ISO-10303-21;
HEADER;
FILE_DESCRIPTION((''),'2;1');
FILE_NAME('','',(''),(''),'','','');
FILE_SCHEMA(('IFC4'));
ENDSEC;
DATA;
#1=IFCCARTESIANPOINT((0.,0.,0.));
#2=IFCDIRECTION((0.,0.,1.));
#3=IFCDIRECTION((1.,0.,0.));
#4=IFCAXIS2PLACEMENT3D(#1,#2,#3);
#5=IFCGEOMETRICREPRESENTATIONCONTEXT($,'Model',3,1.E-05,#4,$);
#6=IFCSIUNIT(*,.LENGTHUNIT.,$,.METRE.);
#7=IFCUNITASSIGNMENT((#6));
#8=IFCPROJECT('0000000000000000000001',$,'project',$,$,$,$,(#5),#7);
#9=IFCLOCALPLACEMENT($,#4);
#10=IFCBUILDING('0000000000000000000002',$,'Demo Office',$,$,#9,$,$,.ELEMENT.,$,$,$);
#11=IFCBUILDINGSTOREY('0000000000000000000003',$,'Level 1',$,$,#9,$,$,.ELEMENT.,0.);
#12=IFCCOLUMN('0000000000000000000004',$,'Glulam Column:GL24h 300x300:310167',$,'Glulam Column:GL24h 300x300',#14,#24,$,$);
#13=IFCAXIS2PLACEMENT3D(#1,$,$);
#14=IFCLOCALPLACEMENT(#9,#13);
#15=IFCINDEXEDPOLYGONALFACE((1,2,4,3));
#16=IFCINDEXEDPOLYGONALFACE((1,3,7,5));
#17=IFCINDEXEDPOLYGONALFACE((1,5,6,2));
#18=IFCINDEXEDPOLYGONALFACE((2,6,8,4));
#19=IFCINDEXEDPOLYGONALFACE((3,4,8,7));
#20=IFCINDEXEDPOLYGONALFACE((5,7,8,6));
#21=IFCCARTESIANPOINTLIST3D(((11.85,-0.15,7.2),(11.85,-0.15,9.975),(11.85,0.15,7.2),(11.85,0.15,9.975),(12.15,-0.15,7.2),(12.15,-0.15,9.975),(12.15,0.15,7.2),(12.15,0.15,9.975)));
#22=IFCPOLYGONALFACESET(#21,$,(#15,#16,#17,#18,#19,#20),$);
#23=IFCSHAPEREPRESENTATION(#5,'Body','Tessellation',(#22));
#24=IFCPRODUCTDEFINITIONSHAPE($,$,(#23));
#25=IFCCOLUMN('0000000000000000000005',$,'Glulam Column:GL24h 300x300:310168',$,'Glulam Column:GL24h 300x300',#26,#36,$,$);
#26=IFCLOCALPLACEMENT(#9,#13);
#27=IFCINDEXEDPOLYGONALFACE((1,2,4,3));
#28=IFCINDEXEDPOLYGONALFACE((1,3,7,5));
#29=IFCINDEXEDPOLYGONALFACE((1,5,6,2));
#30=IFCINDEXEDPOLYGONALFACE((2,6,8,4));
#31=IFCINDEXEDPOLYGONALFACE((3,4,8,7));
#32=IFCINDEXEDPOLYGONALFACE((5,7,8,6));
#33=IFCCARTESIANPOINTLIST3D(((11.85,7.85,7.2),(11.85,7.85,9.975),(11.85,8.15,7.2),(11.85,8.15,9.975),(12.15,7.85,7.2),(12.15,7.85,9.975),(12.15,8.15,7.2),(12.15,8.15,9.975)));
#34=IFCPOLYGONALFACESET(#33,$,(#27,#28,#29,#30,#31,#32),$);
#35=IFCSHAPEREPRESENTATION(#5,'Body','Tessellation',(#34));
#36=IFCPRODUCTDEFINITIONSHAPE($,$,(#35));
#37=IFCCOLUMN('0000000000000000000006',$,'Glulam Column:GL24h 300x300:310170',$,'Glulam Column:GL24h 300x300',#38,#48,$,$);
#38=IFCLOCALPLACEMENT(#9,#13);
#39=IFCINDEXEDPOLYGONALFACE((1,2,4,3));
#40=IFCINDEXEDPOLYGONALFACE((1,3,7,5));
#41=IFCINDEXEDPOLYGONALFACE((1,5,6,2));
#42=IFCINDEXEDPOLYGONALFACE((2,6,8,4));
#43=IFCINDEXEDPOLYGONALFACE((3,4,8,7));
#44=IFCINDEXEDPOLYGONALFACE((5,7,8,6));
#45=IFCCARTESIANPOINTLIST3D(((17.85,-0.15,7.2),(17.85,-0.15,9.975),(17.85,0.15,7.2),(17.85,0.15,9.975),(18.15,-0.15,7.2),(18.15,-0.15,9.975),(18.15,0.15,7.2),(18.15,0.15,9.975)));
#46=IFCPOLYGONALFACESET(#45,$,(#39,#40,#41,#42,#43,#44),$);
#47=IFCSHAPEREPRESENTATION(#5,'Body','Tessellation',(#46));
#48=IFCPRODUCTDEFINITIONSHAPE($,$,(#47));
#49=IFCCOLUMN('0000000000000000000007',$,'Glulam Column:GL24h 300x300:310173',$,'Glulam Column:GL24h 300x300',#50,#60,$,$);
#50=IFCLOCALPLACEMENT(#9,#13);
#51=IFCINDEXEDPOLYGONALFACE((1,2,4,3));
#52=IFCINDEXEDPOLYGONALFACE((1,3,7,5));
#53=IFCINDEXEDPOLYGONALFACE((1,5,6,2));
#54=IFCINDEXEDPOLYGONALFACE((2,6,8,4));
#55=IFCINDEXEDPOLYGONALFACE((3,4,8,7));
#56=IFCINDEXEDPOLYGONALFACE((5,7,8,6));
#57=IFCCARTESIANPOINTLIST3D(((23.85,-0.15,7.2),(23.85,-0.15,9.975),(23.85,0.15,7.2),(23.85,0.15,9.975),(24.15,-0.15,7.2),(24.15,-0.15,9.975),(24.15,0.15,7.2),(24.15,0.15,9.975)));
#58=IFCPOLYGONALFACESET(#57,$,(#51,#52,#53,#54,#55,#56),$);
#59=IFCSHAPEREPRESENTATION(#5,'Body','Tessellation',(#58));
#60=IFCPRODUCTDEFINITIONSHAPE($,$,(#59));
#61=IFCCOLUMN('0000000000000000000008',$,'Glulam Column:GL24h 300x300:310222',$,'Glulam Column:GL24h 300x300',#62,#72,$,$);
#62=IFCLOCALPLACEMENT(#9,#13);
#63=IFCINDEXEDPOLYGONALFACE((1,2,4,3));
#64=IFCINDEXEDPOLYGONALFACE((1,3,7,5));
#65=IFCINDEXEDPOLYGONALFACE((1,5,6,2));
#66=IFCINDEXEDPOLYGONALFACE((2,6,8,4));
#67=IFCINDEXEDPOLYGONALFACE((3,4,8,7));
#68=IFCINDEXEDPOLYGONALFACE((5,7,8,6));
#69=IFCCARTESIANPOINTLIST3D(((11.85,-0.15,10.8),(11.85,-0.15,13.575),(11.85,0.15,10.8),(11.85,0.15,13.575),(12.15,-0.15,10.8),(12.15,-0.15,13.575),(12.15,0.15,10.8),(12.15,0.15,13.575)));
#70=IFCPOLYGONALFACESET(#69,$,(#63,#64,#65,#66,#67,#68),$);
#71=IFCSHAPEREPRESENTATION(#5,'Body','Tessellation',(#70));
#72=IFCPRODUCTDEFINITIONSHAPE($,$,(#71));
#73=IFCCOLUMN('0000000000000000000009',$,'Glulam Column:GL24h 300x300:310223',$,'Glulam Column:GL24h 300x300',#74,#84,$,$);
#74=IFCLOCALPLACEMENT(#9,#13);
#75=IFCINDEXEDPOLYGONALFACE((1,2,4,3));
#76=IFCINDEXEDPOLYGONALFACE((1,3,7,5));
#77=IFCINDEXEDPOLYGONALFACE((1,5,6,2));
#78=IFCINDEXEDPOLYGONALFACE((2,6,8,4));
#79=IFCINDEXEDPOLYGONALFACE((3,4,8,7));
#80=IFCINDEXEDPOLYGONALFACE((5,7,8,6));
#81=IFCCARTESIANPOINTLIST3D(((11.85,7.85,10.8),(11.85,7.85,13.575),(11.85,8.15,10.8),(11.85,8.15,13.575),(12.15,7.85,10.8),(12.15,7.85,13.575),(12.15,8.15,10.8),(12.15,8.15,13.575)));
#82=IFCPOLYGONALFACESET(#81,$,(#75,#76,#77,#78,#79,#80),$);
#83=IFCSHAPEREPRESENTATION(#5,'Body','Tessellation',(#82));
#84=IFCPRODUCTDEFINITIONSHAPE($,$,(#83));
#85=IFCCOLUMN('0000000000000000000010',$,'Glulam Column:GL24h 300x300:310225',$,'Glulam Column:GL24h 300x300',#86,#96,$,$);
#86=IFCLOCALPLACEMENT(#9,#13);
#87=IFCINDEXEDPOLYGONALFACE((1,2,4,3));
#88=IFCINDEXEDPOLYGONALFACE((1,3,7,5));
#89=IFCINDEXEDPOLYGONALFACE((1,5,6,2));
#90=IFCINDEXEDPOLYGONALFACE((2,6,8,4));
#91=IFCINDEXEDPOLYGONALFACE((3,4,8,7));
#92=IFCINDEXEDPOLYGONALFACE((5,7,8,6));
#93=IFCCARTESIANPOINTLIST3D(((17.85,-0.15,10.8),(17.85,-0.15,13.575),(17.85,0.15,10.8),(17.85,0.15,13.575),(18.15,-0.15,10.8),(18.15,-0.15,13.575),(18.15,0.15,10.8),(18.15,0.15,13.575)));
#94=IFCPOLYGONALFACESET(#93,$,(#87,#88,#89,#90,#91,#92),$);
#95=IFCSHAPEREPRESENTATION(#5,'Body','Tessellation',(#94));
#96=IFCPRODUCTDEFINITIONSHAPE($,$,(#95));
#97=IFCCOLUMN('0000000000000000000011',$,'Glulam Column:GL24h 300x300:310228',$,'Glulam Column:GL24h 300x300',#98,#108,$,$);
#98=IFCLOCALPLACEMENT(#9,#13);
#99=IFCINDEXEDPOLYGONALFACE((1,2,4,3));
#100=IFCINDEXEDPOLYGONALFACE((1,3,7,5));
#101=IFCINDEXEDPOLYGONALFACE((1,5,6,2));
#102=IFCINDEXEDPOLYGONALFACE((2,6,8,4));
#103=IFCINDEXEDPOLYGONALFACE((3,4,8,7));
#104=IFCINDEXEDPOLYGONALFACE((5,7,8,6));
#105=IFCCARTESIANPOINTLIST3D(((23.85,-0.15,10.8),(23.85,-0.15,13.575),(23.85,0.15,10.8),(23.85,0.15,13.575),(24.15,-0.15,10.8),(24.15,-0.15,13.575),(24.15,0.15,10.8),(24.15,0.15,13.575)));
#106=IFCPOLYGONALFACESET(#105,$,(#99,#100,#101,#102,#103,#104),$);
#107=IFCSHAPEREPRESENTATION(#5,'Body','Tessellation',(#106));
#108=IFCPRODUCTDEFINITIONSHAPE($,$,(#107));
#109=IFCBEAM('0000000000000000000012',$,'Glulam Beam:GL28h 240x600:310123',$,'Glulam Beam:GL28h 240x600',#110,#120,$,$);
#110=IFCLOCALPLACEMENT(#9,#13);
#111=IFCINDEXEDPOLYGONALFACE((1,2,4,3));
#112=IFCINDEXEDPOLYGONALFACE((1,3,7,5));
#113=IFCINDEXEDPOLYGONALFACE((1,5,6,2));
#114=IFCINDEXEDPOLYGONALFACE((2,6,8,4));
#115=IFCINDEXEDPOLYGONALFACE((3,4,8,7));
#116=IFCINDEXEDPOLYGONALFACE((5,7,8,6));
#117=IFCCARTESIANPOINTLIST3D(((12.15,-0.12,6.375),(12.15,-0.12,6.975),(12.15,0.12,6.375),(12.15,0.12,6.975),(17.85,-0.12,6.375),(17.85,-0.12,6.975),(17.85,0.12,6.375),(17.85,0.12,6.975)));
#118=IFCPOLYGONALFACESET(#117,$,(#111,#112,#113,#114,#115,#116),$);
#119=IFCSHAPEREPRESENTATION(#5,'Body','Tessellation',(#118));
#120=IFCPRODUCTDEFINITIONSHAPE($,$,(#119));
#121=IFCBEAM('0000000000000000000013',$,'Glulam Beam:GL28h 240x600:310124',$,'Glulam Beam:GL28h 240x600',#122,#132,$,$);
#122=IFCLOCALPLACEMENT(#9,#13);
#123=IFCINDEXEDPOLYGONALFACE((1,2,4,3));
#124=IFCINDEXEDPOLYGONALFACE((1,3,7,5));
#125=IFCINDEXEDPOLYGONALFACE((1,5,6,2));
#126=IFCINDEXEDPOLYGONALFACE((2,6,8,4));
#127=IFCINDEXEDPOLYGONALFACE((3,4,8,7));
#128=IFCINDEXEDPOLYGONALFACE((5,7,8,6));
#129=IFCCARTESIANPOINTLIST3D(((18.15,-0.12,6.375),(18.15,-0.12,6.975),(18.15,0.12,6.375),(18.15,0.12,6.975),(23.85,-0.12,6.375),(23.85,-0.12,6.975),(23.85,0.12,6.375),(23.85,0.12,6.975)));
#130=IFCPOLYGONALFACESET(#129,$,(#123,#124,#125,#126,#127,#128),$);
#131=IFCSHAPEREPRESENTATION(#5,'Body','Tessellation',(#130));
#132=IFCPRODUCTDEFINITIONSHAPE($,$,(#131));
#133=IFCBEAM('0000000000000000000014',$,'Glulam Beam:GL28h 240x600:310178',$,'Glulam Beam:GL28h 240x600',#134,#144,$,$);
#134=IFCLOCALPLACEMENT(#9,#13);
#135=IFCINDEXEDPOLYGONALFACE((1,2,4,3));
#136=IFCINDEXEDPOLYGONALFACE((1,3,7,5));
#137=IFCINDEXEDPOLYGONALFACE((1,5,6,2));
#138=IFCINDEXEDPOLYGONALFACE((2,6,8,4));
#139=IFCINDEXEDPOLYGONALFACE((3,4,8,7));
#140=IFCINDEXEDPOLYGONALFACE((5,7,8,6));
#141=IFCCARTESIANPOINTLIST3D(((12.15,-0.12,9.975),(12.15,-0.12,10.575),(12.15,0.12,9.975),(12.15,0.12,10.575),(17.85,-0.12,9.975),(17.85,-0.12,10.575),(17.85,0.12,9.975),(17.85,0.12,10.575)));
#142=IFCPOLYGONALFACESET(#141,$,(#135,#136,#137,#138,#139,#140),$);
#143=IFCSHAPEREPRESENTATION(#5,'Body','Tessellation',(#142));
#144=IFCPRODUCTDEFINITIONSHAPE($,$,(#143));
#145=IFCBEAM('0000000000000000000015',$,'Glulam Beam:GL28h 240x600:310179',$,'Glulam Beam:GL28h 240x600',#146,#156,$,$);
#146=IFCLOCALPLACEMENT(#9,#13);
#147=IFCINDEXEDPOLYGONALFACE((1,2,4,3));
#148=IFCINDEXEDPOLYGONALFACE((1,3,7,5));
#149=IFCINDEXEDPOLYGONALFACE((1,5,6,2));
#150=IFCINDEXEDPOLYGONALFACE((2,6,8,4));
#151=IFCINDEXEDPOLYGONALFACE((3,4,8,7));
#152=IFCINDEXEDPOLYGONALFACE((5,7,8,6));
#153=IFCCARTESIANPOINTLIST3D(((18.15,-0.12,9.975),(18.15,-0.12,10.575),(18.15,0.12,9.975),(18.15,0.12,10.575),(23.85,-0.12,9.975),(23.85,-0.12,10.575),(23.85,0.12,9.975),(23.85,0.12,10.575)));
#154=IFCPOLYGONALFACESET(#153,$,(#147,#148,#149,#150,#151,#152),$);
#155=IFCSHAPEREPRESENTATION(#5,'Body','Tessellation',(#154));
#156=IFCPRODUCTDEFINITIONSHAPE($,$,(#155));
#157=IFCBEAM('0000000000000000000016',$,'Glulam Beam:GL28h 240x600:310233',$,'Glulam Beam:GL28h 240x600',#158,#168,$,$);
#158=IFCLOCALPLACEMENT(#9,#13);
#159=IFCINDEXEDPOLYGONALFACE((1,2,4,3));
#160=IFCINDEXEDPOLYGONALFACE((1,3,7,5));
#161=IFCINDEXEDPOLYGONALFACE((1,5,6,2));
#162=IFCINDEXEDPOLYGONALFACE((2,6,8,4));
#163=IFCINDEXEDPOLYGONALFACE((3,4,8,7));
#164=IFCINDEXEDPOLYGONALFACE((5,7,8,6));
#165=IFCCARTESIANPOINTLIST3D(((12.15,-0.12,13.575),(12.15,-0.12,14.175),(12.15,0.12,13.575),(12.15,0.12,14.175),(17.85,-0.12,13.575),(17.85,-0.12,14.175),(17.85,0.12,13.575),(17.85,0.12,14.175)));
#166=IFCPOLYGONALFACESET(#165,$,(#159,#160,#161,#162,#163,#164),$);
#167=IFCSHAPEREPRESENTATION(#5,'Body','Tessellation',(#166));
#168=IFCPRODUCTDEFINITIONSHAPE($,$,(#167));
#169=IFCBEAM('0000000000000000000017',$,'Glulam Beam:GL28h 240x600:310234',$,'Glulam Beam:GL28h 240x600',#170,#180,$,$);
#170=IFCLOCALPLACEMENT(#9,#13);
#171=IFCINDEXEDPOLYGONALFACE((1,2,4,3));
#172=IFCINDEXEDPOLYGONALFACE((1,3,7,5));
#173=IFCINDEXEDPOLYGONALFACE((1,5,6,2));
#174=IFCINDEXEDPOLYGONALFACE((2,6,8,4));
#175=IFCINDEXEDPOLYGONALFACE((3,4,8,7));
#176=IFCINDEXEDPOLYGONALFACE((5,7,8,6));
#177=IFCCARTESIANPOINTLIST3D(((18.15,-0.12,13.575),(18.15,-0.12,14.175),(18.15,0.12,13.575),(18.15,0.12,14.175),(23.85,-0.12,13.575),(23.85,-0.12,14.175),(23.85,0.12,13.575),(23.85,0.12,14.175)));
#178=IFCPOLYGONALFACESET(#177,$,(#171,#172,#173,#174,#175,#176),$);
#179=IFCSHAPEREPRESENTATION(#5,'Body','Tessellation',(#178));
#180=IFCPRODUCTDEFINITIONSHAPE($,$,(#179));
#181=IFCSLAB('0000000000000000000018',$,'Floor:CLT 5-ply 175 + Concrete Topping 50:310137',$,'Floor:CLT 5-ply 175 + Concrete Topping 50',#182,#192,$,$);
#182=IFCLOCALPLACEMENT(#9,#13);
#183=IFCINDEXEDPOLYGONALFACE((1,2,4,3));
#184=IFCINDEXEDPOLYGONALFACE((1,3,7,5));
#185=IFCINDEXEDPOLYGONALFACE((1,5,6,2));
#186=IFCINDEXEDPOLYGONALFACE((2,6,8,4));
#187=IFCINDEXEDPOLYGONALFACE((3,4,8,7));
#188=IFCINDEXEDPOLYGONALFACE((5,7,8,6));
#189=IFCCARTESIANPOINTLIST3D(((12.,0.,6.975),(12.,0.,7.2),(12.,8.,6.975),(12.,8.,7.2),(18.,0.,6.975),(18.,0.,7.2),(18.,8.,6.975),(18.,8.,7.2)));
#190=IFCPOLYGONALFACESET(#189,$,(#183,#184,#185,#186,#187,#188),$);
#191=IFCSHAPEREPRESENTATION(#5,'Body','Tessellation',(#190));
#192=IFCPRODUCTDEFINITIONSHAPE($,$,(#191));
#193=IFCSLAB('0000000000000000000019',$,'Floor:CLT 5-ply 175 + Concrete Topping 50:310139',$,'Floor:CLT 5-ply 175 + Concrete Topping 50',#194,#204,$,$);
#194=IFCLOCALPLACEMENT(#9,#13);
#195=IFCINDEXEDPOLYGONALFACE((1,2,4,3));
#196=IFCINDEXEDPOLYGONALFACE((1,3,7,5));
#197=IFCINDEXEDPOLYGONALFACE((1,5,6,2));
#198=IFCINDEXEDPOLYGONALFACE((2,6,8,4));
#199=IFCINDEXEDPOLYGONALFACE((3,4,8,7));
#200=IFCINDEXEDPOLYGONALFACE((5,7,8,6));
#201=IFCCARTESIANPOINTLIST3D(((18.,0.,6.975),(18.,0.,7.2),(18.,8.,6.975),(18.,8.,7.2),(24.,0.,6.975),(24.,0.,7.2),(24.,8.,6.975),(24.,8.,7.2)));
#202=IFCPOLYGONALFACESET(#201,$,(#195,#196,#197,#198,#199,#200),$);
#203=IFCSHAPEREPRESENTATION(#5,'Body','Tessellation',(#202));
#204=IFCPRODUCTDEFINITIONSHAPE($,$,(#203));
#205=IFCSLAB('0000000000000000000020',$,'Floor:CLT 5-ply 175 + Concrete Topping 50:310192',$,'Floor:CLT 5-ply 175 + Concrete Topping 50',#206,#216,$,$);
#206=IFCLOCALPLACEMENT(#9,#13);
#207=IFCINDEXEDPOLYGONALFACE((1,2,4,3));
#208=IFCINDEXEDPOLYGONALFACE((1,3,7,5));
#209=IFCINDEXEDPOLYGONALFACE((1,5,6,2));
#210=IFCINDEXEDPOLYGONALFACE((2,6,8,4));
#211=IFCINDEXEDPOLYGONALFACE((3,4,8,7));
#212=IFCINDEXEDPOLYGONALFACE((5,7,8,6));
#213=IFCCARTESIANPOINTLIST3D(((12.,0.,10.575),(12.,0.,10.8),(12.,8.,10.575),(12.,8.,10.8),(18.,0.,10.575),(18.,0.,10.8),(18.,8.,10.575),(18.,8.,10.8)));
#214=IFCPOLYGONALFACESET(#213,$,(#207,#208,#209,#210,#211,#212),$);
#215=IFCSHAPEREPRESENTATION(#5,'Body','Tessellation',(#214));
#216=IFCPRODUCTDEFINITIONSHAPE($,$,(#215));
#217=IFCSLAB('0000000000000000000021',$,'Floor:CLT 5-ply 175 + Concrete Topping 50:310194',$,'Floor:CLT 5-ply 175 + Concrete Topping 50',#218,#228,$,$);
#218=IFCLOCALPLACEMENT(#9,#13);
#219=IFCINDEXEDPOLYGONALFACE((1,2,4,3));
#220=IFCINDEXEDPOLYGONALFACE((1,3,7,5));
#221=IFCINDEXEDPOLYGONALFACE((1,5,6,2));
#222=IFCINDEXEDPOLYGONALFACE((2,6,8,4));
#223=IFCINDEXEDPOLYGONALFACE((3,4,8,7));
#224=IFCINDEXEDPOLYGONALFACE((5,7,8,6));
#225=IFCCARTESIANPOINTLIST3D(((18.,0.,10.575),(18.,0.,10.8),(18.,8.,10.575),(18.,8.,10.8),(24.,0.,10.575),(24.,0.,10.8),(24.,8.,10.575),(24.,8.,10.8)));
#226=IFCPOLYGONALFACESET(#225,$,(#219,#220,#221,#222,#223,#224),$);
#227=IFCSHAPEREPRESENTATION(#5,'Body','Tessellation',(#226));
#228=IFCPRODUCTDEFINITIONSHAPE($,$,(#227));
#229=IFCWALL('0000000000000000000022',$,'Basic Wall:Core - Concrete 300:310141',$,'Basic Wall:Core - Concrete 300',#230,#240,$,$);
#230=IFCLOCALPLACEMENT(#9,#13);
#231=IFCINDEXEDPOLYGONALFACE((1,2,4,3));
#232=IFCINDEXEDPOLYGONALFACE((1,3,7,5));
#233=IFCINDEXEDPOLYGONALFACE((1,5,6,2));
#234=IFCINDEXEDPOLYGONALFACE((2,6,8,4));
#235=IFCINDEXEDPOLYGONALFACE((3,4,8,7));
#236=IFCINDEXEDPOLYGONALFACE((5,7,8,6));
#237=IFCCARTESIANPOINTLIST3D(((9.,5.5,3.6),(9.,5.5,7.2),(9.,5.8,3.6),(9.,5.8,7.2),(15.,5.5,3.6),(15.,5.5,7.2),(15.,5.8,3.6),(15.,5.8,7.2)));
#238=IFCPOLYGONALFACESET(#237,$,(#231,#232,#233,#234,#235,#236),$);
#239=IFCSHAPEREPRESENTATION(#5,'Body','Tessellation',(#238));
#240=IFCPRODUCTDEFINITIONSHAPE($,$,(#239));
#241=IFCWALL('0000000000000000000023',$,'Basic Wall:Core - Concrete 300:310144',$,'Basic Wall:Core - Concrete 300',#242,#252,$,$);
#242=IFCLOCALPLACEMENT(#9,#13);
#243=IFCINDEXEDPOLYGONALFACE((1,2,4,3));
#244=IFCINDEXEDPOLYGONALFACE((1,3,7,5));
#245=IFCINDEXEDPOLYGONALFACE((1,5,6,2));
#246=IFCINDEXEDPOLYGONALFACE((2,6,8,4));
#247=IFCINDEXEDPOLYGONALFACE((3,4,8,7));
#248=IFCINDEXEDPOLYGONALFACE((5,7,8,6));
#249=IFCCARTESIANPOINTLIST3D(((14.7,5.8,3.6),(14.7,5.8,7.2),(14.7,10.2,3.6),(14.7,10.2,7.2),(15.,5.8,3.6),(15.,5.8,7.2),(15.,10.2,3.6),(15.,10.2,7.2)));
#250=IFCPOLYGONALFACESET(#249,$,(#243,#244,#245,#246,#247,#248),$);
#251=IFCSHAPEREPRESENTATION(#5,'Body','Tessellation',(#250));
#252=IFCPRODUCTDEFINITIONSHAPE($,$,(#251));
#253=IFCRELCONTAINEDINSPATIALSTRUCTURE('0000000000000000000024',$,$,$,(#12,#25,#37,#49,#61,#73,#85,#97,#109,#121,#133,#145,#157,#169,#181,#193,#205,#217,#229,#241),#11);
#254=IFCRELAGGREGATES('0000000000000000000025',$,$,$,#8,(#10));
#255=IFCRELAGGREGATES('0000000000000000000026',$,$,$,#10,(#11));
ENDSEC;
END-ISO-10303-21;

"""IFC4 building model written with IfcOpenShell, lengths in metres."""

from ifc_helpers import new_model, si_unit, frame, origin_with_axes, origin_2d, place, context, project, spatial, rectangle, extrude, element, save


model = new_model("IFC4")

# Units and contexts
model_context = context("Model", 3, precision=1e-05, world=origin_with_axes())
ifc_project = project(units=[si_unit("LENGTHUNIT", "METRE")], contexts=[model_context])

# Building, storey
placement = place(None, origin_with_axes())
building = spatial("IfcBuilding", under=ifc_project, at=placement, Name="Demo Office", CompositionType="ELEMENT")
storey = spatial("IfcBuildingStorey", under=building, at=placement, Name="Level 1", CompositionType="ELEMENT", Elevation=0.0)

# Columns
for number, where, name in (
    (1, (12.0, 0.0, 7.2), "Glulam Column:GL24h 300x300:310167"),
    (2, (12.0, 8.0, 7.2), "Glulam Column:GL24h 300x300:310168"),
    (3, (18.0, 0.0, 7.2), "Glulam Column:GL24h 300x300:310170"),
    (4, (24.0, 0.0, 7.2), "Glulam Column:GL24h 300x300:310173"),
    (5, (12.0, 0.0, 10.8), "Glulam Column:GL24h 300x300:310222"),
    (6, (12.0, 8.0, 10.8), "Glulam Column:GL24h 300x300:310223"),
    (7, (18.0, 0.0, 10.8), "Glulam Column:GL24h 300x300:310225"),
    (8, (24.0, 0.0, 10.8), "Glulam Column:GL24h 300x300:310228"),
):
    element("IfcColumn", number, at=place(placement, frame(where)), inside=storey, Name=name, ObjectType="Glulam Column:GL24h 300x300", context=model_context, shape_type="SweptSolid", body=[
        extrude(rectangle(XDim=0.3, YDim=0.3, at=origin_2d()), origin_with_axes(), (0.0, 0.0, 1.0), 2.775),
    ])

# Beams
for number, where, name in (
    (9, (15.0, 0.0, 6.375), "Glulam Beam:GL28h 240x600:310123"),
    (10, (21.0, 0.0, 6.375), "Glulam Beam:GL28h 240x600:310124"),
    (11, (15.0, 0.0, 9.975), "Glulam Beam:GL28h 240x600:310178"),
    (12, (21.0, 0.0, 9.975), "Glulam Beam:GL28h 240x600:310179"),
    (13, (15.0, 0.0, 13.575), "Glulam Beam:GL28h 240x600:310233"),
    (14, (21.0, 0.0, 13.575), "Glulam Beam:GL28h 240x600:310234"),
):
    element("IfcBeam", number, at=place(placement, frame(where)), inside=storey, Name=name, ObjectType="Glulam Beam:GL28h 240x600", context=model_context, shape_type="SweptSolid", body=[
        extrude(rectangle(XDim=5.7, YDim=0.24, at=origin_2d()), origin_with_axes(), (0.0, 0.0, 1.0), 0.6),
    ])

# Slabs
for number, where, name in (
    (15, (15.0, 4.0, 6.975), "Floor:CLT 5-ply 175 + Concrete Topping 50:310137"),
    (16, (21.0, 4.0, 6.975), "Floor:CLT 5-ply 175 + Concrete Topping 50:310139"),
    (17, (15.0, 4.0, 10.575), "Floor:CLT 5-ply 175 + Concrete Topping 50:310192"),
    (18, (21.0, 4.0, 10.575), "Floor:CLT 5-ply 175 + Concrete Topping 50:310194"),
):
    element("IfcSlab", number, at=place(placement, frame(where)), inside=storey, Name=name, ObjectType="Floor:CLT 5-ply 175 + Concrete Topping 50", context=model_context, shape_type="SweptSolid", body=[
        extrude(rectangle(XDim=6.0, YDim=8.0, at=origin_2d()), origin_with_axes(), (0.0, 0.0, 1.0), 0.225),
    ])

# Walls
wall_1_placement = place(placement, frame((12.0, 5.65, 3.6)))
element("IfcWall", 19, at=wall_1_placement, inside=storey, Name="Basic Wall:Core - Concrete 300:310141", ObjectType="Basic Wall:Core - Concrete 300", context=model_context, shape_type="SweptSolid", body=[
    extrude(rectangle(XDim=6.0, YDim=0.3, at=origin_2d()), origin_with_axes(), (0.0, 0.0, 1.0), 3.6),
])
wall_2_placement = place(placement, frame((14.85, 8.0, 3.6)))
element("IfcWall", 20, at=wall_2_placement, inside=storey, Name="Basic Wall:Core - Concrete 300:310144", ObjectType="Basic Wall:Core - Concrete 300", context=model_context, shape_type="SweptSolid", body=[
    extrude(rectangle(XDim=0.3, YDim=4.4, at=origin_2d()), origin_with_axes(), (0.0, 0.0, 1.0), 3.6),
])

save(model, "model.ifc")
